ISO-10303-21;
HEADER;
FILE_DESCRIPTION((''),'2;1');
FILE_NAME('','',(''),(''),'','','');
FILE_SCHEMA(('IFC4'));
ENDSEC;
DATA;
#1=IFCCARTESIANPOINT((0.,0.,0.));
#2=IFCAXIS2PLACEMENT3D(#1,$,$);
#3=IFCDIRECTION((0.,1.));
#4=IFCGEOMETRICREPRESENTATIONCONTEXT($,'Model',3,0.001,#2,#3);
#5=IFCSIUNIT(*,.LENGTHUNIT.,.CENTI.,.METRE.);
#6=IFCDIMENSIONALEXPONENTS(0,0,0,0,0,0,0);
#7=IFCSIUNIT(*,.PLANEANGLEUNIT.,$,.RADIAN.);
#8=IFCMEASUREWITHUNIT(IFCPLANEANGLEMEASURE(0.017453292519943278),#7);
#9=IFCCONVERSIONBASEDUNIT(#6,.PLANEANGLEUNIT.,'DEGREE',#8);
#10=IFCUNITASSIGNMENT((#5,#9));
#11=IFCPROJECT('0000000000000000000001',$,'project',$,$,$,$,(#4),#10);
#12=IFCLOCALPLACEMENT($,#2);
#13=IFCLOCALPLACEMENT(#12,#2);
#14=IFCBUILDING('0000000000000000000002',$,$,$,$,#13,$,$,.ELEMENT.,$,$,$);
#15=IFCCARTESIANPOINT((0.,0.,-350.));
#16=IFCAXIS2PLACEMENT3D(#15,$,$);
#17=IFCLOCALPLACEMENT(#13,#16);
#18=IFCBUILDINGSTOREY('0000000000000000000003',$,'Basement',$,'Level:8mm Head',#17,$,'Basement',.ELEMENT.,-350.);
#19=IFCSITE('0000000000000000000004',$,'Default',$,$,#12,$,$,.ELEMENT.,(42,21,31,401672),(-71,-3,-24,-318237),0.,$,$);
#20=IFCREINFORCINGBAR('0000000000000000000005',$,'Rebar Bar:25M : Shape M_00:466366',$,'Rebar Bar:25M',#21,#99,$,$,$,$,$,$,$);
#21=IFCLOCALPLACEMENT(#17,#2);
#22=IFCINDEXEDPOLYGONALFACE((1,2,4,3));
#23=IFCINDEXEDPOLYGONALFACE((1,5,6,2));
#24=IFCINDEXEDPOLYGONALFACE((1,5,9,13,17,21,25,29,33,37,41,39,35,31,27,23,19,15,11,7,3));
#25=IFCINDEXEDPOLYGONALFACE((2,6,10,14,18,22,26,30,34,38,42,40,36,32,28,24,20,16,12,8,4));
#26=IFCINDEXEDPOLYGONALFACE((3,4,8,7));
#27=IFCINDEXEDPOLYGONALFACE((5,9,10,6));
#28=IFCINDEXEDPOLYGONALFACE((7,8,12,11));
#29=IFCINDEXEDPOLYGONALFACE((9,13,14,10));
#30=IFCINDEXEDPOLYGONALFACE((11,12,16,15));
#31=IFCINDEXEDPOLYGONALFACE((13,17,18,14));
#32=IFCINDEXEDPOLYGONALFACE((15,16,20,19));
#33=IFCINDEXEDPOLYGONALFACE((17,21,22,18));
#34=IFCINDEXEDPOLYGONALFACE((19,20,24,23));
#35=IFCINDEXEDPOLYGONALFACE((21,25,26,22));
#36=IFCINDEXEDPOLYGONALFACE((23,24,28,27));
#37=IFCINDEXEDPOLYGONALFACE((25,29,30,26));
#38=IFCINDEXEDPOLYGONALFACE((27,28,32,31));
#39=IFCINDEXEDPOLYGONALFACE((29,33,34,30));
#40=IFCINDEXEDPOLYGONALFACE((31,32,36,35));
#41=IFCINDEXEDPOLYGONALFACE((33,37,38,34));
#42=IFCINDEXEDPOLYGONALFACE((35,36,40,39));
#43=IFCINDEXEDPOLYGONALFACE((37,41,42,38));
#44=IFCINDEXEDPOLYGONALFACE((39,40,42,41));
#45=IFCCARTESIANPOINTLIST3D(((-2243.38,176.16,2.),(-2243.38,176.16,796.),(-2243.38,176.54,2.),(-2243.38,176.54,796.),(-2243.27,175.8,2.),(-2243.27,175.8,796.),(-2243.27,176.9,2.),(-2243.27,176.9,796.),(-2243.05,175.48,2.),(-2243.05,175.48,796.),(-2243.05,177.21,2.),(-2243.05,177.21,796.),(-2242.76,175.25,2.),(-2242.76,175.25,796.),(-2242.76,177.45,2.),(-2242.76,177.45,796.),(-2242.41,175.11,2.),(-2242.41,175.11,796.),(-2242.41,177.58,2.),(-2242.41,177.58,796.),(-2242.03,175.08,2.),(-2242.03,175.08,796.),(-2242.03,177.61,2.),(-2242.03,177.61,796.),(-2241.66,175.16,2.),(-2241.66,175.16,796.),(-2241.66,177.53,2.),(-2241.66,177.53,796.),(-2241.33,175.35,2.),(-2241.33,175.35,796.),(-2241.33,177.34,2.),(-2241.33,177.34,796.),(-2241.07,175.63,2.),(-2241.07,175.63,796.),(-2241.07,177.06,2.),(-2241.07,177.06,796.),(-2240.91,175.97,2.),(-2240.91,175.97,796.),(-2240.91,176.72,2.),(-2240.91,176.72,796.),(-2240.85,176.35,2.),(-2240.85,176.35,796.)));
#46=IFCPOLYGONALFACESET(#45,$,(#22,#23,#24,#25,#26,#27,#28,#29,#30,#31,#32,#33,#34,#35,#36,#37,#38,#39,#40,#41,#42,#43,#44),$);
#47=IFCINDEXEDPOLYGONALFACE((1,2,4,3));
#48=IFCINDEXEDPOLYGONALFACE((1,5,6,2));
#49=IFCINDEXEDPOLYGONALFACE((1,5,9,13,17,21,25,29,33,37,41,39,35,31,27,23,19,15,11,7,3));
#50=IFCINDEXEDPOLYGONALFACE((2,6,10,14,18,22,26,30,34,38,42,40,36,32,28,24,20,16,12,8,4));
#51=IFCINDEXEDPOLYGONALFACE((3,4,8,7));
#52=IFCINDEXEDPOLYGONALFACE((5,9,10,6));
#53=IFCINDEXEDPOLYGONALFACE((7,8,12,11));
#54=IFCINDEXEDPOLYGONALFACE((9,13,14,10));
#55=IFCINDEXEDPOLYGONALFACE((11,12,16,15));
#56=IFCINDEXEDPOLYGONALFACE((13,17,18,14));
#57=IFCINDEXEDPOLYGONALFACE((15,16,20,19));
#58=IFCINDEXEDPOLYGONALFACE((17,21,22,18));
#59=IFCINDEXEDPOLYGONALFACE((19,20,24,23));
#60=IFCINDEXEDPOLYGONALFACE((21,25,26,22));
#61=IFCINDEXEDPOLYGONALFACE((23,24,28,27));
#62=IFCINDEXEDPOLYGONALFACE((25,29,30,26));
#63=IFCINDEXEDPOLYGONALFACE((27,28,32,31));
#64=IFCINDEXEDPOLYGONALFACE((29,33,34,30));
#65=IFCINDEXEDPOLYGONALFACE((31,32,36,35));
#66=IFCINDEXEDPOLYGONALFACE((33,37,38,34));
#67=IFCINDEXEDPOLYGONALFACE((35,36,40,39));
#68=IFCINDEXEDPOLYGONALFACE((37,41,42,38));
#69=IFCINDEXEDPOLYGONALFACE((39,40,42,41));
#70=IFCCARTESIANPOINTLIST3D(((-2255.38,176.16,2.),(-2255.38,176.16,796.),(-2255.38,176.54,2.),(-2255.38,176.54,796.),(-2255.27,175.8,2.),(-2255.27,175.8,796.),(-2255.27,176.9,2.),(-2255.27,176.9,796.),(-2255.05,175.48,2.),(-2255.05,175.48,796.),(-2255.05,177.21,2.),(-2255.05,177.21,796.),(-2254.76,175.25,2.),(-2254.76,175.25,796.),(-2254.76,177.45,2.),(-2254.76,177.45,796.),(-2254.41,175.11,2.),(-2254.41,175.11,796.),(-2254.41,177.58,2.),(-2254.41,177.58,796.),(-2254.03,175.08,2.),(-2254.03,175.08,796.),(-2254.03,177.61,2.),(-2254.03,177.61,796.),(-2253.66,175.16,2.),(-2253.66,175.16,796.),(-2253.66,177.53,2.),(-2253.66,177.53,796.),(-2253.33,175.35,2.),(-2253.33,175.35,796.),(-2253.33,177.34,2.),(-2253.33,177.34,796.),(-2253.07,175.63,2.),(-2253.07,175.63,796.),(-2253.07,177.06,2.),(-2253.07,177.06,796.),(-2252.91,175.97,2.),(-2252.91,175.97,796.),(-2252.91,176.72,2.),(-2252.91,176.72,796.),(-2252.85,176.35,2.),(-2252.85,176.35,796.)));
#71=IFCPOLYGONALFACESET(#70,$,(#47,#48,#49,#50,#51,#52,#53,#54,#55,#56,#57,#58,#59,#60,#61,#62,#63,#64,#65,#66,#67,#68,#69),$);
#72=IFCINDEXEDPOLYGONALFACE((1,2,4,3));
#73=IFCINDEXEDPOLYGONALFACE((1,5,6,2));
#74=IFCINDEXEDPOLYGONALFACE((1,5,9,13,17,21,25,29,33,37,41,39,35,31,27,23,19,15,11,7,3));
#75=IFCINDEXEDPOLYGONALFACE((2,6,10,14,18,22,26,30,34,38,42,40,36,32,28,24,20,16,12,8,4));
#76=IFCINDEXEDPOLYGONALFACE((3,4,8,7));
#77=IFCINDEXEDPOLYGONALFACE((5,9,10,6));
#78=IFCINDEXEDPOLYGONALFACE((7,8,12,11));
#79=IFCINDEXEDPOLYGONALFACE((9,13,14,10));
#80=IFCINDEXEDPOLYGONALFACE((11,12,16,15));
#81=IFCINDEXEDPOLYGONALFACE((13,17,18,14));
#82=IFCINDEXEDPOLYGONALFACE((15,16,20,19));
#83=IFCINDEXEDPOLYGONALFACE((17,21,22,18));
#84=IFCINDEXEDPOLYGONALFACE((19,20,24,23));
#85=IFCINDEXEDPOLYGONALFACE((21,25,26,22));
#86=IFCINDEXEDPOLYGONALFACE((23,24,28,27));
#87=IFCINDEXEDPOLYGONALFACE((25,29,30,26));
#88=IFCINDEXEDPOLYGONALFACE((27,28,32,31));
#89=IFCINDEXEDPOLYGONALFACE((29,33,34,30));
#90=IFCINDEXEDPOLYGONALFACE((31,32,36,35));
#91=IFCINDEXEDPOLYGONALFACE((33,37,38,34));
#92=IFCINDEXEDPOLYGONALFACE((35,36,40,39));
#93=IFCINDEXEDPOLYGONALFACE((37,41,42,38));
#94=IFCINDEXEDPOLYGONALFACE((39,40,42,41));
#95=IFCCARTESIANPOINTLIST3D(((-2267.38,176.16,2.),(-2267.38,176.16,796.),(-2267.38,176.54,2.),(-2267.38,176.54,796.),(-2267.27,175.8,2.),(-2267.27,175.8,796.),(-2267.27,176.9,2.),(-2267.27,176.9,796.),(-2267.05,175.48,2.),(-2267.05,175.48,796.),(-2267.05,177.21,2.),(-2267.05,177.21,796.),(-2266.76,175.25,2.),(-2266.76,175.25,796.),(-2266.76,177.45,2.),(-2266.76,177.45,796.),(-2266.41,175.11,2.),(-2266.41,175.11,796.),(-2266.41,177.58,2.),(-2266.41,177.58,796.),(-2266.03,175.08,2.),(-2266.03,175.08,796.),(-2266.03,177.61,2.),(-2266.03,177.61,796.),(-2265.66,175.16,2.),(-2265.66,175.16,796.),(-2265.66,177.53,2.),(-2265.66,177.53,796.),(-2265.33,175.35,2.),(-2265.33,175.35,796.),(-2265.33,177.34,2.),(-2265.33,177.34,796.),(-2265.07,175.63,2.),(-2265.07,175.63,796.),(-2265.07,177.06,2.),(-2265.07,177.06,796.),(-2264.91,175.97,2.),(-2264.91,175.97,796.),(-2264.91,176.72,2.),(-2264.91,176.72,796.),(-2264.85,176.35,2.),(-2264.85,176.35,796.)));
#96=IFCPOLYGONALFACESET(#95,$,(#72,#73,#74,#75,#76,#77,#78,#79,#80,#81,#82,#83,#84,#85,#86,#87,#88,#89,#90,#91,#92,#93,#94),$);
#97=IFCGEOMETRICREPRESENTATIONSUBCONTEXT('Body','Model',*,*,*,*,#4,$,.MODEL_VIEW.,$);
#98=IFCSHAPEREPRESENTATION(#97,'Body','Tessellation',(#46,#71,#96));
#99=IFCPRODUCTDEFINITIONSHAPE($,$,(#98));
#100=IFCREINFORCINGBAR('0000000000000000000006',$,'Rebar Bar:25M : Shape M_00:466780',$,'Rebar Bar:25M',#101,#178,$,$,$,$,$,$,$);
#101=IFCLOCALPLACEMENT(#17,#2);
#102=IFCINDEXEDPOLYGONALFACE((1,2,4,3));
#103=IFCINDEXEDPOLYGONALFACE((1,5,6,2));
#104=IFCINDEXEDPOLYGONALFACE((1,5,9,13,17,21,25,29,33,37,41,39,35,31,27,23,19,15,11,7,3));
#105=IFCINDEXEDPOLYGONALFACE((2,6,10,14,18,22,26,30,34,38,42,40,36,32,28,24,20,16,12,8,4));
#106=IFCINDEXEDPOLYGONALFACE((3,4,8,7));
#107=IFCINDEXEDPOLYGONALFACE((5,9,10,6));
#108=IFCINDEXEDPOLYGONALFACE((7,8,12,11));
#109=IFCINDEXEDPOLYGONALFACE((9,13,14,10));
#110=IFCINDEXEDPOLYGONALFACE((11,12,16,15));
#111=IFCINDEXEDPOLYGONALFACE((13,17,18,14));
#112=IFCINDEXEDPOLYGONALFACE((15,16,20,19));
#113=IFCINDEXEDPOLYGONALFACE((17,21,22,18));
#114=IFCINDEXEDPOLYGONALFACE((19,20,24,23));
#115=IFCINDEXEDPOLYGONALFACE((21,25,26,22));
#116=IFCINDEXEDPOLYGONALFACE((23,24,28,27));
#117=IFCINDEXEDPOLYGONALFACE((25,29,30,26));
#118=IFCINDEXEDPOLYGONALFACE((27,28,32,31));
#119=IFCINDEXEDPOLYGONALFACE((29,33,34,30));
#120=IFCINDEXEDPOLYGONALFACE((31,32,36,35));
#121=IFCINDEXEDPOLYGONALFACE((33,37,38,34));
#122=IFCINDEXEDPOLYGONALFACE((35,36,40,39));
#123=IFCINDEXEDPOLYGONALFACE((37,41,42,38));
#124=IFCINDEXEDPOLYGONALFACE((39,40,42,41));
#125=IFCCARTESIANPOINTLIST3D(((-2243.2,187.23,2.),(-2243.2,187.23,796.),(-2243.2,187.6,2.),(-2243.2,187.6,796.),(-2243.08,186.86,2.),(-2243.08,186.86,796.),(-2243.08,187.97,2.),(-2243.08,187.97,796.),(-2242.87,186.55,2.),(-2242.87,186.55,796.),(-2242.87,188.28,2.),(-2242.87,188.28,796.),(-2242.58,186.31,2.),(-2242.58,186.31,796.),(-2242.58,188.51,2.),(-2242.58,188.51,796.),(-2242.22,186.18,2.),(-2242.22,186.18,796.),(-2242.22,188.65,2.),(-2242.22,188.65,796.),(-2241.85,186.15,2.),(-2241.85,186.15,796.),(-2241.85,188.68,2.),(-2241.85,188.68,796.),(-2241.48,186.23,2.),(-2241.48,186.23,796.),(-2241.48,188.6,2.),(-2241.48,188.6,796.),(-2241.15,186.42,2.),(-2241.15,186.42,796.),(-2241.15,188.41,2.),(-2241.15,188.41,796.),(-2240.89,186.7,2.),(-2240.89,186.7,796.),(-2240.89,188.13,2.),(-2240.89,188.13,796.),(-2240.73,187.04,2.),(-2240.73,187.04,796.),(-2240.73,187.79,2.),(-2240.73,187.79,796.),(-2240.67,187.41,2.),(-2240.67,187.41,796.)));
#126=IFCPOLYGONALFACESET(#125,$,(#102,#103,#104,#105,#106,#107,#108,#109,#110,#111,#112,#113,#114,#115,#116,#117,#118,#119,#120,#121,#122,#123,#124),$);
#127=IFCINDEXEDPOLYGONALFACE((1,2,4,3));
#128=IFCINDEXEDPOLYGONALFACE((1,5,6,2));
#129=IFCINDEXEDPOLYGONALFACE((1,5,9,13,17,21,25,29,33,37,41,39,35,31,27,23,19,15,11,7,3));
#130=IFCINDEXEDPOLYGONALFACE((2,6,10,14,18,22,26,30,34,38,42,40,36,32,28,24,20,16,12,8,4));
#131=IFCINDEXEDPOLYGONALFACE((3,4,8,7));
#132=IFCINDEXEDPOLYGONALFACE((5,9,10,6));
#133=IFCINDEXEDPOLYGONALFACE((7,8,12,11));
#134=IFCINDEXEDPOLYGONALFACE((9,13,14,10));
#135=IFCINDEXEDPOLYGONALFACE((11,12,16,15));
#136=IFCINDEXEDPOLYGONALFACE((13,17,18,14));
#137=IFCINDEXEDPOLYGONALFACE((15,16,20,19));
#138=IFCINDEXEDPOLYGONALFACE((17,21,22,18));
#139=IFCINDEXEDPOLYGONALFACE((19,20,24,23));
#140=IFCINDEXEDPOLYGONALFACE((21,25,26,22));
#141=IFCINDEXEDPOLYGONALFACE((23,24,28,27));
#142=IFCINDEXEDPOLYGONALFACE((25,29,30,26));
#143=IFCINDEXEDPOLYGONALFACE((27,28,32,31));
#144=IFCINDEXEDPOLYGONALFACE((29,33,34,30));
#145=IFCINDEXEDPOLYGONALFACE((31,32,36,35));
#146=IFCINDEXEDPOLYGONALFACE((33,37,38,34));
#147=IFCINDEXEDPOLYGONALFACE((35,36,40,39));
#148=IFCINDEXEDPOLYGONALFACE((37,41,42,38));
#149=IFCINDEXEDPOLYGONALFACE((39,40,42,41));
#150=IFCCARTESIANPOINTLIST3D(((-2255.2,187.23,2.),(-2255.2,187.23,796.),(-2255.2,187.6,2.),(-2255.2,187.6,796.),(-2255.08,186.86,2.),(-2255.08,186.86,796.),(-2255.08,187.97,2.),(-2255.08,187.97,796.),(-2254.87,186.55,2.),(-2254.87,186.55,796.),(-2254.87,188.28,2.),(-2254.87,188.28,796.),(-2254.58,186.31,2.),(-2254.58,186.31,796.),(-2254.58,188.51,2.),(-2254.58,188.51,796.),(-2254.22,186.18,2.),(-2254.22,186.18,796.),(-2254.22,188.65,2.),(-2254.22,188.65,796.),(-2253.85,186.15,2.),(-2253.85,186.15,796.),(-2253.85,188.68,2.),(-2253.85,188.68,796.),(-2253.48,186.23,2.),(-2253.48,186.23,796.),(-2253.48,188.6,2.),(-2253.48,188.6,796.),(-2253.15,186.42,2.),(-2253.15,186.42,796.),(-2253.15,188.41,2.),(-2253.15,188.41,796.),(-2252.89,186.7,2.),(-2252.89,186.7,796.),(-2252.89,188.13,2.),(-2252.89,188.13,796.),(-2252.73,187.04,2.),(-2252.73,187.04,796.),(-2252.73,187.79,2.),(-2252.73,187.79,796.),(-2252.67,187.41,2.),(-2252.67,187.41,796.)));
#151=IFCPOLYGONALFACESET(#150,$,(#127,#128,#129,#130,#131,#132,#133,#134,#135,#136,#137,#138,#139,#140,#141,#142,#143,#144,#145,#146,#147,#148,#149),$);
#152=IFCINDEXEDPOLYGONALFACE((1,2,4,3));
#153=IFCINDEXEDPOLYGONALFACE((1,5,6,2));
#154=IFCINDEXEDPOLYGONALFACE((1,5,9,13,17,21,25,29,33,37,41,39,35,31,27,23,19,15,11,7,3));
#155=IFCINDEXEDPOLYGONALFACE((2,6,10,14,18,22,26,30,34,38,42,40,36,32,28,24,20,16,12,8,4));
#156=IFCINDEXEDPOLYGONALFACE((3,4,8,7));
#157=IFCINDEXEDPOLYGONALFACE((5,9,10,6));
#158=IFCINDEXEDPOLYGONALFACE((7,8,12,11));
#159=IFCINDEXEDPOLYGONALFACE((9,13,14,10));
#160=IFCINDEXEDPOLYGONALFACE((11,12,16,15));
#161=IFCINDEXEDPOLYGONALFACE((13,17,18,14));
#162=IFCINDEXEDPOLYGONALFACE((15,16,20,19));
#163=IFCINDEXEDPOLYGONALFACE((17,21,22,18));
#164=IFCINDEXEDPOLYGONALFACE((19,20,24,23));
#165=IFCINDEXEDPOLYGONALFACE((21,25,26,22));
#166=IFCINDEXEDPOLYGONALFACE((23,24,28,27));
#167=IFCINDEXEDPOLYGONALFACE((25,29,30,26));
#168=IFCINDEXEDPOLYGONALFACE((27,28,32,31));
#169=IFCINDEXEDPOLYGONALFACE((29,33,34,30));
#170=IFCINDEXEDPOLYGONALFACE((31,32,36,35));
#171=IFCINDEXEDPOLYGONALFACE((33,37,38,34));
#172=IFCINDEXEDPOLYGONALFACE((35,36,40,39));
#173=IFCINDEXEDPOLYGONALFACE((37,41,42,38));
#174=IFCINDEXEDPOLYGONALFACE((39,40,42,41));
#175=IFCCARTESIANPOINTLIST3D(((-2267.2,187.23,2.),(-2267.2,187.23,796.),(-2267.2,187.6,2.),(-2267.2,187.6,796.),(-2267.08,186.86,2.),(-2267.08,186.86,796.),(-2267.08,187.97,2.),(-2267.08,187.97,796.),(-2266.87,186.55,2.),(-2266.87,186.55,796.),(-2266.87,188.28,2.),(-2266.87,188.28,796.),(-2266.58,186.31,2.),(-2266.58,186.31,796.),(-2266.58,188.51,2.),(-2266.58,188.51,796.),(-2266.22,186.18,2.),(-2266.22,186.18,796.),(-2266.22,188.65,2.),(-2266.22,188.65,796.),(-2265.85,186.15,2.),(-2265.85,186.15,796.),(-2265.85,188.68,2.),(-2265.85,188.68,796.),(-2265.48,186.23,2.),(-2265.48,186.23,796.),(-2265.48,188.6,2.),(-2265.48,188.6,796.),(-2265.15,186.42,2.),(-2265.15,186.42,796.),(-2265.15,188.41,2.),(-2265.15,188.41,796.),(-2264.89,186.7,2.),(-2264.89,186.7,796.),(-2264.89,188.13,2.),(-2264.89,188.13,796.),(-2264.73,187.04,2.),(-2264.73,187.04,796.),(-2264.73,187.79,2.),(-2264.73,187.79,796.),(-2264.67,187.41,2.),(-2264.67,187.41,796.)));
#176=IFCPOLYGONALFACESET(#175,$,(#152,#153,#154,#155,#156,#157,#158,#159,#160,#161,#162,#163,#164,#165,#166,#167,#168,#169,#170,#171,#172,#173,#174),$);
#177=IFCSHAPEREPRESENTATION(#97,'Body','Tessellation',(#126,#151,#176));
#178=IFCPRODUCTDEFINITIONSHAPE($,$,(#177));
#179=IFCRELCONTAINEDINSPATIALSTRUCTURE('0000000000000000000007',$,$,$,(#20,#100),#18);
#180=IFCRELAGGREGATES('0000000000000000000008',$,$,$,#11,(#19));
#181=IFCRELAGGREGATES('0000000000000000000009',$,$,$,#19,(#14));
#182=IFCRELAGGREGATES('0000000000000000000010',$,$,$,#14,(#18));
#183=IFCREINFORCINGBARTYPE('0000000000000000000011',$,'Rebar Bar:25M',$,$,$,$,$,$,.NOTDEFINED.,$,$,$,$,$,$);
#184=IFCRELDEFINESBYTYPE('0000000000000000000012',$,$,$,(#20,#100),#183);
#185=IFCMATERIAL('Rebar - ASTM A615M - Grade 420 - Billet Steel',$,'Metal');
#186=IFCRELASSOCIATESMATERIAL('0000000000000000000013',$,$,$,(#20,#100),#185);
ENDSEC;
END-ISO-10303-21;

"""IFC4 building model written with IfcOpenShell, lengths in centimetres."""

from ifc_helpers import new_model, entity, si_unit, converted_unit, direction, frame, origin, place, context, subcontext, project, spatial, material, type_object, element, save


model = new_model("IFC4")

# Units and contexts
model_context = context("Model", 3, precision=0.001, world=origin(), true_north=direction((0.0, 1.0)))
body_context = subcontext(model_context, "Body", "Model", "MODEL_VIEW")
ifc_project = project(units=[si_unit("LENGTHUNIT", "METRE", prefix="CENTI"), converted_unit("PLANEANGLEUNIT", "DEGREE", entity("IfcPlaneAngleMeasure", 0.017453292519943278), si_unit("PLANEANGLEUNIT", "RADIAN"), dimensions=[0, 0, 0, 0, 0, 0, 0])], contexts=[model_context])

# Site, building, storey
site_placement = place(None, origin())
site = spatial("IfcSite", under=ifc_project, at=site_placement, Name="Default", CompositionType="ELEMENT", RefLatitude=(42, 21, 31, 401672), RefLongitude=(-71, -3, -24, -318237), RefElevation=0.0)
building_placement = place(site_placement, origin())
building = spatial("IfcBuilding", under=site, at=building_placement, CompositionType="ELEMENT")
storey_placement = place(building_placement, frame((0.0, 0.0, -350.0)))
storey = spatial("IfcBuildingStorey", under=building, at=storey_placement, Name="Basement", ObjectType="Level:8mm Head", LongName="Basement", CompositionType="ELEMENT", Elevation=-350.0)

# Reinforcing bars
ifc_material_1 = material(Name="Rebar - ASTM A615M - Grade 420 - Billet Steel", Category="Metal")
reinforcing_bar_type_1 = type_object("IfcReinforcingBarType", Name="Rebar Bar:25M", PredefinedType="NOTDEFINED")
reinforcing_bar_1_placement = place(storey_placement, origin())
element("IfcReinforcingBar", 1, at=reinforcing_bar_1_placement, inside=storey, type_object=reinforcing_bar_type_1, material=ifc_material_1, Name="Rebar Bar:25M : Shape M_00:466366", ObjectType="Rebar Bar:25M", context=body_context, shape_type="AdvancedSweptSolid", body=[
    entity("IfcSweptDiskSolid", entity("IfcIndexedPolyCurve", entity("IfcCartesianPointList3D", [[-2242.12, 176.35, 2.0], [-2242.12, 176.35, 796.0]]), None, False), 1.27, None, 0.0, 1.0),
    entity("IfcSweptDiskSolid", entity("IfcIndexedPolyCurve", entity("IfcCartesianPointList3D", [[-2254.12, 176.35, 2.0], [-2254.12, 176.35, 796.0]]), None, False), 1.27, None, 0.0, 1.0),
    entity("IfcSweptDiskSolid", entity("IfcIndexedPolyCurve", entity("IfcCartesianPointList3D", [[-2266.12, 176.35, 2.0], [-2266.12, 176.35, 796.0]]), None, False), 1.27, None, 0.0, 1.0),
])
reinforcing_bar_2_placement = place(storey_placement, origin())
element("IfcReinforcingBar", 2, at=reinforcing_bar_2_placement, inside=storey, type_object=reinforcing_bar_type_1, material=ifc_material_1, Name="Rebar Bar:25M : Shape M_00:466780", ObjectType="Rebar Bar:25M", context=body_context, shape_type="AdvancedSweptSolid", body=[
    entity("IfcSweptDiskSolid", entity("IfcIndexedPolyCurve", entity("IfcCartesianPointList3D", [[-2241.94, 187.41, 2.0], [-2241.94, 187.41, 796.0]]), None, False), 1.27, None, 0.0, 1.0),
    entity("IfcSweptDiskSolid", entity("IfcIndexedPolyCurve", entity("IfcCartesianPointList3D", [[-2253.94, 187.41, 2.0], [-2253.94, 187.41, 796.0]]), None, False), 1.27, None, 0.0, 1.0),
    entity("IfcSweptDiskSolid", entity("IfcIndexedPolyCurve", entity("IfcCartesianPointList3D", [[-2265.94, 187.41, 2.0], [-2265.94, 187.41, 796.0]]), None, False), 1.27, None, 0.0, 1.0),
])

save(model, "model.ifc")
